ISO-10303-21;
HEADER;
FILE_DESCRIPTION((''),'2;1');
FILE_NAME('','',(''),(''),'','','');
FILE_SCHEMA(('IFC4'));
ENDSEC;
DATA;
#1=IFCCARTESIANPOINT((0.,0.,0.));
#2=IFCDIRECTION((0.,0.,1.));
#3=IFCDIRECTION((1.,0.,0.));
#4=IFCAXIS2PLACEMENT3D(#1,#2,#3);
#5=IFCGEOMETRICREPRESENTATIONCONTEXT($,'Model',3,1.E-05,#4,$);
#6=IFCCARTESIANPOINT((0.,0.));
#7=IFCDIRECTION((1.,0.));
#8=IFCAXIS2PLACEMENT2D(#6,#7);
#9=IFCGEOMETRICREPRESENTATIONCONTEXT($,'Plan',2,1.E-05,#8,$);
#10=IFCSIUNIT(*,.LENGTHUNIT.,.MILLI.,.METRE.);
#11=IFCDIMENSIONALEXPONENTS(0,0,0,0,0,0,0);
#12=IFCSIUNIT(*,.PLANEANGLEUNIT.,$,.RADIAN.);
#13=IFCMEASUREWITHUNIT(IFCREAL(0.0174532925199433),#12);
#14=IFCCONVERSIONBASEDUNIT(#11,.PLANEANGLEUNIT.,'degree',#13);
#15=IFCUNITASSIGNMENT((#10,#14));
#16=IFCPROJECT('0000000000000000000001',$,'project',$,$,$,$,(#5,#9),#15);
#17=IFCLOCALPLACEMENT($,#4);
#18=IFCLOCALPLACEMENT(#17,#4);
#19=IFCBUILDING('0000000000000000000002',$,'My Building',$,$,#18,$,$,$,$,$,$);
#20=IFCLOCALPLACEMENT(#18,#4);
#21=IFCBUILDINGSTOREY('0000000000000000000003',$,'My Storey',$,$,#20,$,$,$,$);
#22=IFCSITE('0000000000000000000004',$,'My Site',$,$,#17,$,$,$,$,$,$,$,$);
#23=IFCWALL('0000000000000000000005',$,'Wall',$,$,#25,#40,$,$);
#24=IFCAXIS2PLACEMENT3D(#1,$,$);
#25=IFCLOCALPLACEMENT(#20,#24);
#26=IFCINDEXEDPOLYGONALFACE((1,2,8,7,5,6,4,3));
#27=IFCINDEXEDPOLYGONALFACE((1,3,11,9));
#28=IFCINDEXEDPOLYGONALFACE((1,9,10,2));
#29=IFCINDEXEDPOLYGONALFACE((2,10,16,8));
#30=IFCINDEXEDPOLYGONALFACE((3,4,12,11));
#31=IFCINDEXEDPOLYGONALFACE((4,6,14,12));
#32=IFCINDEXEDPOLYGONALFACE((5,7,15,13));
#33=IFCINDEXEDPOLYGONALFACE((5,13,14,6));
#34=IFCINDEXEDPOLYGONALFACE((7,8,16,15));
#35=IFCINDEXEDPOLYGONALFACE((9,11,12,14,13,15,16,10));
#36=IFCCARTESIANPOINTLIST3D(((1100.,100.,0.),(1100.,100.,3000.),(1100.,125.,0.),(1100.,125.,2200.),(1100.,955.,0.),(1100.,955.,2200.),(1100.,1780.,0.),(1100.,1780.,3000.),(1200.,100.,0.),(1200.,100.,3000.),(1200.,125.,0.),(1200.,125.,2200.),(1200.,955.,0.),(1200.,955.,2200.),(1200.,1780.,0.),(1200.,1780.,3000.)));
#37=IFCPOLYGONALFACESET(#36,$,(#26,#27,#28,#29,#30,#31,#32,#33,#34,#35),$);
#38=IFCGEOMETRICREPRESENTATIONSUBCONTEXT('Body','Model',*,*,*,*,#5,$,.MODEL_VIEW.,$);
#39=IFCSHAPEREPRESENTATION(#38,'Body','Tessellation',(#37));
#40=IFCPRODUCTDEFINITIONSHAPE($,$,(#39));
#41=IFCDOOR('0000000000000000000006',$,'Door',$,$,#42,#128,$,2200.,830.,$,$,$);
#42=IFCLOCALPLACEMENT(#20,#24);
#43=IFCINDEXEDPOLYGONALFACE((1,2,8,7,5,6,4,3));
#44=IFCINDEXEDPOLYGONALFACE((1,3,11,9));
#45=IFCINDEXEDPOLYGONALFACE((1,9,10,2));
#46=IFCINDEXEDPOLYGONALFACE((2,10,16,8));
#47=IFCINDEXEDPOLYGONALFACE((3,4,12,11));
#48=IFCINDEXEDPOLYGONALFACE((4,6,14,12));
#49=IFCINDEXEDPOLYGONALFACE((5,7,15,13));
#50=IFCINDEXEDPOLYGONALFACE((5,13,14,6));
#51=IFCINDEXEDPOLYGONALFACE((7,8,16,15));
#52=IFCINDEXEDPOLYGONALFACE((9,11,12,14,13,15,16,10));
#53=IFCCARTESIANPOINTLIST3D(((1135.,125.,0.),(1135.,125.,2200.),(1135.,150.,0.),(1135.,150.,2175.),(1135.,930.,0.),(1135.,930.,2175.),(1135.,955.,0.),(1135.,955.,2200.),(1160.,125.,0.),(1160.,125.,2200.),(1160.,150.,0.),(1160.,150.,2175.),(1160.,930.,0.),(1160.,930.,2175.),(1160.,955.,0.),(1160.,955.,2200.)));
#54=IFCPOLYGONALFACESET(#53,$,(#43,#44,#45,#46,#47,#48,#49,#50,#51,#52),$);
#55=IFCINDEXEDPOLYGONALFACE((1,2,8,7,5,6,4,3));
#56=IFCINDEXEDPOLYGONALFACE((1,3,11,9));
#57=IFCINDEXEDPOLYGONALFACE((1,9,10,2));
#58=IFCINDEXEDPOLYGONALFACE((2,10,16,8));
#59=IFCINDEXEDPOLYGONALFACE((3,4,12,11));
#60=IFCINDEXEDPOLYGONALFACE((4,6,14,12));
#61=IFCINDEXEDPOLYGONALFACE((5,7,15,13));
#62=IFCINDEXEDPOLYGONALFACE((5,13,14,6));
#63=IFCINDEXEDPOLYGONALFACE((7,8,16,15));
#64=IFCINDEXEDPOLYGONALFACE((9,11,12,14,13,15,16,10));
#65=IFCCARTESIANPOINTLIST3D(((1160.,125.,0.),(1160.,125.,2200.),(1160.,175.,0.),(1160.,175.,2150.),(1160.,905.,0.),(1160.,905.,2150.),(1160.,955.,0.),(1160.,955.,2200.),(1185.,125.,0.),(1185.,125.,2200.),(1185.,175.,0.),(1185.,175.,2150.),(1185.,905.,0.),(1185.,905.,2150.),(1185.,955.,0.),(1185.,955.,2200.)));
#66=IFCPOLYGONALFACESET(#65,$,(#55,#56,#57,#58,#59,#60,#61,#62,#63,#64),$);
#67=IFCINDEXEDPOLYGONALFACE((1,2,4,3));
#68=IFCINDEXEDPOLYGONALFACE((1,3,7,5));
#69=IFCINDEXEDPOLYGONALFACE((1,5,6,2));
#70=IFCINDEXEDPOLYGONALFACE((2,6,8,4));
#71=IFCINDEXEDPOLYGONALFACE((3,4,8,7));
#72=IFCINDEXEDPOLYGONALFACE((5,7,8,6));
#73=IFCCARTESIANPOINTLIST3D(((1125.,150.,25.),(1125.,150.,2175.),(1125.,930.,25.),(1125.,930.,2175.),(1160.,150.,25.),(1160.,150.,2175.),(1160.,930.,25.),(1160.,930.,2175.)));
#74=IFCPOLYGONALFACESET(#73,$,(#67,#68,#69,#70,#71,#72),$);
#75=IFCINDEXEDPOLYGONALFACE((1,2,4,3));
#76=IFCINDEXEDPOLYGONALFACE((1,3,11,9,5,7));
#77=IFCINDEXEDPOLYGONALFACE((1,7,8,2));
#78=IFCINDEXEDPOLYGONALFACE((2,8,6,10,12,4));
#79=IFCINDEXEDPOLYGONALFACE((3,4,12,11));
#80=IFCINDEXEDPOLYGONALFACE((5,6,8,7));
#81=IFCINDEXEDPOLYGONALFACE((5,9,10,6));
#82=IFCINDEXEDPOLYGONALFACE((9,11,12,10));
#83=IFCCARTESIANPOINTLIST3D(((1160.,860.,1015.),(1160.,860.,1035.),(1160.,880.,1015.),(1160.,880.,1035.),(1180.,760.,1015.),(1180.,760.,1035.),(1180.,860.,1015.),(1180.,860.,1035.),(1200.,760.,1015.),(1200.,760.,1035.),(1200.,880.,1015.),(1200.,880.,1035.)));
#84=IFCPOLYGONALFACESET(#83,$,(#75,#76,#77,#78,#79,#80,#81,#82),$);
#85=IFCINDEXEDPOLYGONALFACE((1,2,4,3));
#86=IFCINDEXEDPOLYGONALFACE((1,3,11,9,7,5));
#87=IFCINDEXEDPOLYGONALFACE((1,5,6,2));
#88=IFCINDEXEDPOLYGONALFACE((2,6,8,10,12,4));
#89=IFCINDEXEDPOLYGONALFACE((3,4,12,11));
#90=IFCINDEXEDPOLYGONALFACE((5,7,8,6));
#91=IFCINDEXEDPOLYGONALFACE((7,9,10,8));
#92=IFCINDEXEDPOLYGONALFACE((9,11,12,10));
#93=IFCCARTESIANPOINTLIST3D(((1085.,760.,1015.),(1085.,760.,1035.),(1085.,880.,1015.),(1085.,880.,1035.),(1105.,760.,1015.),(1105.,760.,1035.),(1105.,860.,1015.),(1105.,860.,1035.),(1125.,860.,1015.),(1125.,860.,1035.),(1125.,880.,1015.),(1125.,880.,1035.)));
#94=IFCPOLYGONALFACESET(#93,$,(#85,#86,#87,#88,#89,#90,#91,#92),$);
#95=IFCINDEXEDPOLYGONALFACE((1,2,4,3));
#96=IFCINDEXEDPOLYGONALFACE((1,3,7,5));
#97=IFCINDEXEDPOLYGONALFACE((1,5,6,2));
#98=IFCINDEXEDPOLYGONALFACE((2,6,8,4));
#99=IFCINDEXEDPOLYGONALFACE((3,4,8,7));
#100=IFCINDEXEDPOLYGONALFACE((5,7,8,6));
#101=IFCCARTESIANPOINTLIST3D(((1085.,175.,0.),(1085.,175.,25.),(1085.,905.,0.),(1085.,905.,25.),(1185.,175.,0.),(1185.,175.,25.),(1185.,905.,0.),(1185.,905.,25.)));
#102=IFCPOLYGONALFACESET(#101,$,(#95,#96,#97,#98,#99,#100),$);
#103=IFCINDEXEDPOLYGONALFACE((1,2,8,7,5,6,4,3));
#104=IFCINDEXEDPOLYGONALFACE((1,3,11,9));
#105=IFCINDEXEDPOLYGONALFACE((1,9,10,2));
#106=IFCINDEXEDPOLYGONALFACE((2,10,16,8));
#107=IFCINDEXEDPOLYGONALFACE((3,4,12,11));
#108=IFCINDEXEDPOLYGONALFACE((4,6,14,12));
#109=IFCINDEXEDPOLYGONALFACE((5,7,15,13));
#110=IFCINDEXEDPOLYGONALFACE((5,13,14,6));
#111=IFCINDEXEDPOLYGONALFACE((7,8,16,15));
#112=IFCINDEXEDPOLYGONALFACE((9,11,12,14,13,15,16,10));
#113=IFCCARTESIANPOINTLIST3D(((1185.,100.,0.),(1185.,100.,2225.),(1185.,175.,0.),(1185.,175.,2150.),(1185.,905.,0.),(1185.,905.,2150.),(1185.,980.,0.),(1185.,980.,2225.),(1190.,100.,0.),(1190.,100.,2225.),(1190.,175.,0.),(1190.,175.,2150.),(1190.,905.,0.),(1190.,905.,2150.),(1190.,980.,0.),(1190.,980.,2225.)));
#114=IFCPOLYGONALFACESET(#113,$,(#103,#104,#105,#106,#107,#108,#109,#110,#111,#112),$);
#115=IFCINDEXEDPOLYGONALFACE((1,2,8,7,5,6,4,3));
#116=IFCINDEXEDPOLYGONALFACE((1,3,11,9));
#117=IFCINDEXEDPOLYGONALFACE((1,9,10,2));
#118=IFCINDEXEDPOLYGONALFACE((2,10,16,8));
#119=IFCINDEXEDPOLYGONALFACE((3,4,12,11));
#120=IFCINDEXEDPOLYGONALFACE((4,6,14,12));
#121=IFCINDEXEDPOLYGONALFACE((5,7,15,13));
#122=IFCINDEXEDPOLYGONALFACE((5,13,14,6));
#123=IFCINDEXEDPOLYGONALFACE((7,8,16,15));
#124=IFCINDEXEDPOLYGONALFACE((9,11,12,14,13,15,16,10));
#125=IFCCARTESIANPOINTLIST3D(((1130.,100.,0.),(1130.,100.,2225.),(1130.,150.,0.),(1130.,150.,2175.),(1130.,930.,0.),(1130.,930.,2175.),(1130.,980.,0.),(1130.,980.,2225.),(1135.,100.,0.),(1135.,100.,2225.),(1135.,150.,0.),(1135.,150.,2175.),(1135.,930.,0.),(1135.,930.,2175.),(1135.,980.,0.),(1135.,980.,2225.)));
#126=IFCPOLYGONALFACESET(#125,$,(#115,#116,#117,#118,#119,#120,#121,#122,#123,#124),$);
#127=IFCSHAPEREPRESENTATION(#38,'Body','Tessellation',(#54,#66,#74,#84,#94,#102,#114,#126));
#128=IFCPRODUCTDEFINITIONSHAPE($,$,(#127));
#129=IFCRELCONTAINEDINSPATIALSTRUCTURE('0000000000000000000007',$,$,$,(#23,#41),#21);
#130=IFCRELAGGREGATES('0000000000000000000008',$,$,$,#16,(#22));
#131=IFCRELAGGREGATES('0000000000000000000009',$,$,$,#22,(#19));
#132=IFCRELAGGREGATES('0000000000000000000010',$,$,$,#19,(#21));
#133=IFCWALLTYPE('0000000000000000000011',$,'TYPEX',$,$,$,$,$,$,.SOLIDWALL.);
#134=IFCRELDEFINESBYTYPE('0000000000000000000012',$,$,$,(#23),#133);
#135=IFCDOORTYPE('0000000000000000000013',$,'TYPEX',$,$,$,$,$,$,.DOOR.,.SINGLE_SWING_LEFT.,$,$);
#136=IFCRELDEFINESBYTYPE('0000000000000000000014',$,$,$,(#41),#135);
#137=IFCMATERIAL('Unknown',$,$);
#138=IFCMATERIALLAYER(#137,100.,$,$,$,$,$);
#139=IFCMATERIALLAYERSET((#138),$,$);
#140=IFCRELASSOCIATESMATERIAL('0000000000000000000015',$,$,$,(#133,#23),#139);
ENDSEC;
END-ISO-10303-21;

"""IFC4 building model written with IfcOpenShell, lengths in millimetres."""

from ifc_helpers import new_model, entity, si_unit, converted_unit, frame, origin_with_axes, origin_2d_with_axis, place, context, subcontext, project, spatial, line, indexed_curve, outline, extrude, shape, source, transform, mapped, material, layer, layer_set, layer_usage, type_object, type_shapes, element, fill, save


model = new_model("IFC4")

# Units and contexts
model_context = context("Model", 3, precision=1e-05, world=origin_with_axes())
plan_context = context("Plan", 2, precision=1e-05, world=origin_2d_with_axis())
body_context_1 = subcontext(model_context, "Body", "Model", "MODEL_VIEW")
body_context_2 = subcontext(plan_context, "Body", "Plan", "PLAN_VIEW")
ifc_project = project(units=[si_unit("LENGTHUNIT", "METRE", prefix="MILLI"), converted_unit("PLANEANGLEUNIT", "degree", entity("IfcReal", 0.0174532925199433), si_unit("PLANEANGLEUNIT", "RADIAN"), dimensions=[0, 0, 0, 0, 0, 0, 0])], contexts=[model_context, plan_context])

# Site, building, storey
site_placement = place(None, origin_with_axes())
site = spatial("IfcSite", under=ifc_project, at=site_placement, Name="My Site")
building_placement = place(site_placement, origin_with_axes())
building = spatial("IfcBuilding", under=site, at=building_placement, Name="My Building")
storey_placement = place(building_placement, origin_with_axes())
storey = spatial("IfcBuildingStorey", under=building, at=storey_placement, Name="My Storey")

# Shared definitions
ifc_material = material(Name="Unknown")

# Shared definitions
ifc_layer_1 = layer(ifc_material, 100.0)
ifc_layer_set_1 = layer_set([ifc_layer_1])
wall_type = type_object("IfcWallType", Name="TYPEX", PredefinedType="SOLIDWALL", material=ifc_layer_set_1)
shared_shape_1 = source(origin_with_axes(), body_context_1, "Body", "SweptSolid", [
    extrude(outline(indexed_curve([(0.0, 0.0), (830.0, 0.0), (830.0, 2200.0), (0.0, 2200.0)], segments=[line(1, 2, 3, 4, 1)])), frame((0.0, -100.0, 0.0), z_axis=(0.0, -1.0, 0.0), x_axis=(1.0, 0.0, 0.0)), (0.0, 0.0, -1.0), 300.0),
])
door_type = type_object("IfcDoorType", Name="TYPEX", OperationType="SINGLE_SWING_LEFT", PredefinedType="DOOR")
shared_shape_2 = source(origin_with_axes(), body_context_1, "Body", "SweptSolid", [
    extrude(outline(indexed_curve([(0.0, 0.0), (0.0, 2200.0), (830.0, 2200.0), (830.0, 0.0), (805.0, 0.0), (805.0, 2175.0), (25.0, 2175.0), (25.0, 0.0)], segments=[line(1, 2, 3, 4, 5, 6, 7, 8, 1)])), frame((0.0, 25.0, 0.0), z_axis=(0.0, -1.0, 0.0), x_axis=(1.0, 0.0, 0.0)), (0.0, 0.0, -1.0), 25.0),
    extrude(outline(indexed_curve([(0.0, 0.0), (0.0, 2200.0), (830.0, 2200.0), (830.0, 0.0), (780.0, 0.0), (780.0, 2150.0), (50.0, 2150.0), (50.0, 0.0)], segments=[line(1, 2, 3, 4, 5, 6, 7, 8, 1)])), frame((0.0, 0.0, 0.0), z_axis=(0.0, -1.0, 0.0), x_axis=(1.0, 0.0, 0.0)), (0.0, 0.0, -1.0), 25.0),
    extrude(outline(indexed_curve([(0.0, 0.0), (780.0, 0.0), (780.0, 35.0), (0.0, 35.0)], segments=[line(1, 2, 3, 4, 1)])), frame((25.0, 25.0, 25.0), z_axis=(0.0, 0.0, 1.0), x_axis=(1.0, 0.0, 0.0)), (0.0, 0.0, 1.0), 2150.0),
    extrude(outline(indexed_curve([(0.0, 0.0), (0.0, -40.0), (-120.0, -40.0), (-120.0, -20.0), (-20.0, -20.0), (-20.0, 0.0)], segments=[line(1, 2, 3, 4, 5, 6, 1)])), frame((755.0, 25.0, 1015.0), z_axis=(0.0, 0.0, 1.0), x_axis=(1.0, 0.0, 0.0)), (0.0, 0.0, 1.0), 20.0),
    extrude(outline(indexed_curve([(0.0, 0.0), (0.0, 40.0), (-120.0, 40.0), (-120.0, 20.0), (-20.0, 20.0), (-20.0, 0.0)], segments=[line(1, 2, 3, 4, 5, 6, 1)])), frame((755.0, 60.0, 1015.0), z_axis=(0.0, 0.0, 1.0), x_axis=(1.0, 0.0, 0.0)), (0.0, 0.0, 1.0), 20.0),
    extrude(outline(indexed_curve([(0.0, 0.0), (730.0, 0.0), (730.0, 100.0), (0.0, 100.0)], segments=[line(1, 2, 3, 4, 1)])), frame((50.0, 0.0, 0.0), z_axis=(0.0, 0.0, 1.0), x_axis=(1.0, 0.0, 0.0)), (0.0, 0.0, 1.0), 25.0),
    extrude(outline(indexed_curve([(0.0, 0.0), (0.0, 2225.0), (880.0, 2225.0), (880.0, 0.0), (805.0, 0.0), (805.0, 2150.0), (75.0, 2150.0), (75.0, 0.0)], segments=[line(1, 2, 3, 4, 5, 6, 7, 8, 1)])), frame((-25.0, -5.0, 0.0), z_axis=(0.0, -1.0, 0.0), x_axis=(1.0, 0.0, 0.0)), (0.0, 0.0, -1.0), 5.0),
    extrude(outline(indexed_curve([(0.0, 0.0), (0.0, 2225.0), (880.0, 2225.0), (880.0, 0.0), (830.0, 0.0), (830.0, 2175.0), (50.0, 2175.0), (50.0, 0.0)], segments=[line(1, 2, 3, 4, 5, 6, 7, 8, 1)])), frame((-25.0, 50.0, 0.0), z_axis=(0.0, -1.0, 0.0), x_axis=(1.0, 0.0, 0.0)), (0.0, 0.0, -1.0), 5.0),
])
shared_shape_3 = source(origin_with_axes(), body_context_2, "Body", "Curve2D", [
    entity("IfcIndexedPolyCurve", entity("IfcCartesianPointList2D", [[0.0, 0.0], [0.0, 50.0], [25.0, 50.0], [25.0, 25.0], [50.0, 25.0], [50.0, 0.0]]), [entity("IfcLineIndex", [1, 2, 3, 4, 5, 6, 1])]),
    entity("IfcIndexedPolyCurve", entity("IfcCartesianPointList2D", [[830.0, 0.0], [830.0, 50.0], [805.0, 50.0], [805.0, 25.0], [780.0, 25.0], [780.0, 0.0]]), [entity("IfcLineIndex", [1, 2, 3, 4, 5, 6, 1])]),
    entity("IfcTrimmedCurve", entity("IfcEllipse", entity("IfcAxis2Placement2D", entity("IfcCartesianPoint", [60.0, 50.0]), entity("IfcDirection", [1.0, 0.0])), 745.0, 780.0), [entity("IfcCartesianPoint", [805.0, 50.0])], [entity("IfcCartesianPoint", [60.0, 830.0])], True, "CARTESIAN"),
    entity("IfcIndexedPolyCurve", entity("IfcCartesianPointList2D", [[25.0, 50.0], [60.0, 50.0], [60.0, 830.0], [25.0, 830.0]]), [entity("IfcLineIndex", [1, 2, 3, 4, 1])]),
])
type_shapes(door_type, [shared_shape_2, shared_shape_3])

# Wall, opening, door
ifc_layer_usage_1 = layer_usage(ifc_layer_set_1, "AXIS2", "POSITIVE", 0.0)
wall_1_placement = place(storey_placement, frame((1100.0, 1780.0, 0.0), z_axis=(0.0, 0.0, 1.0), x_axis=(-0.000001, -1.0, 0.0)))
wall_1 = element("IfcWall", 1, at=wall_1_placement, inside=storey, type_object=wall_type, material=ifc_layer_usage_1, Name="Wall", context=body_context_1, shape_type="SweptSolid", body=[
    extrude(outline(indexed_curve([(0.0, 0.0), (0.0, 100.0), (1680.0, 100.0), (1680.0, 0.0), (0.0, 0.0)], self_intersect=False)), origin_with_axes(), (0.0, 0.0, 1.0), 3000.0),
])
opening_1_placement = place(wall_1_placement, frame((825.0, 0.0, 0.0), z_axis=(0.0, 0.0, 1.0), x_axis=(1.0, 0.0, 0.0)))
opening_1 = element("IfcOpeningElement", 2, at=opening_1_placement, cuts=wall_1, PredefinedType="OPENING", context=body_context_1, shape_type="MappedRepresentation", body=[
    mapped(shared_shape_1, transform((0.0, 0.0, 0.0), x_axis=(1.0, 0.0, 0.0), y_axis=(0.0, 1.0, 0.0), z_axis=(0.0, 0.0, 1.0), scale=1.0)),
])
door_1_placement = place(opening_1_placement, frame((830.0, 85.0, 0.0), z_axis=(0.0, 0.0, 1.0), x_axis=(-1.0, 0.0, 0.0)))
door_1 = element("IfcDoor", 3, at=door_1_placement, inside=storey, type_object=door_type, Name="Door", OverallHeight=2200.0, OverallWidth=830.0, shapes=[
    shape(body_context_1, "Body", "MappedRepresentation", [mapped(shared_shape_2, transform((0.0, 0.0, 0.0), x_axis=(1.0, 0.0, 0.0), y_axis=(0.0, 1.0, 0.0), z_axis=(0.0, 0.0, 1.0), scale=1.0))]),
    shape(body_context_2, "Body", "MappedRepresentation", [mapped(shared_shape_3, transform((0.0, 0.0, 0.0), x_axis=(1.0, 0.0, 0.0), y_axis=(0.0, 1.0, 0.0), z_axis=(0.0, 0.0, 1.0), scale=1.0))]),
])
fill(opening_1, door_1)

save(model, "model.ifc")
